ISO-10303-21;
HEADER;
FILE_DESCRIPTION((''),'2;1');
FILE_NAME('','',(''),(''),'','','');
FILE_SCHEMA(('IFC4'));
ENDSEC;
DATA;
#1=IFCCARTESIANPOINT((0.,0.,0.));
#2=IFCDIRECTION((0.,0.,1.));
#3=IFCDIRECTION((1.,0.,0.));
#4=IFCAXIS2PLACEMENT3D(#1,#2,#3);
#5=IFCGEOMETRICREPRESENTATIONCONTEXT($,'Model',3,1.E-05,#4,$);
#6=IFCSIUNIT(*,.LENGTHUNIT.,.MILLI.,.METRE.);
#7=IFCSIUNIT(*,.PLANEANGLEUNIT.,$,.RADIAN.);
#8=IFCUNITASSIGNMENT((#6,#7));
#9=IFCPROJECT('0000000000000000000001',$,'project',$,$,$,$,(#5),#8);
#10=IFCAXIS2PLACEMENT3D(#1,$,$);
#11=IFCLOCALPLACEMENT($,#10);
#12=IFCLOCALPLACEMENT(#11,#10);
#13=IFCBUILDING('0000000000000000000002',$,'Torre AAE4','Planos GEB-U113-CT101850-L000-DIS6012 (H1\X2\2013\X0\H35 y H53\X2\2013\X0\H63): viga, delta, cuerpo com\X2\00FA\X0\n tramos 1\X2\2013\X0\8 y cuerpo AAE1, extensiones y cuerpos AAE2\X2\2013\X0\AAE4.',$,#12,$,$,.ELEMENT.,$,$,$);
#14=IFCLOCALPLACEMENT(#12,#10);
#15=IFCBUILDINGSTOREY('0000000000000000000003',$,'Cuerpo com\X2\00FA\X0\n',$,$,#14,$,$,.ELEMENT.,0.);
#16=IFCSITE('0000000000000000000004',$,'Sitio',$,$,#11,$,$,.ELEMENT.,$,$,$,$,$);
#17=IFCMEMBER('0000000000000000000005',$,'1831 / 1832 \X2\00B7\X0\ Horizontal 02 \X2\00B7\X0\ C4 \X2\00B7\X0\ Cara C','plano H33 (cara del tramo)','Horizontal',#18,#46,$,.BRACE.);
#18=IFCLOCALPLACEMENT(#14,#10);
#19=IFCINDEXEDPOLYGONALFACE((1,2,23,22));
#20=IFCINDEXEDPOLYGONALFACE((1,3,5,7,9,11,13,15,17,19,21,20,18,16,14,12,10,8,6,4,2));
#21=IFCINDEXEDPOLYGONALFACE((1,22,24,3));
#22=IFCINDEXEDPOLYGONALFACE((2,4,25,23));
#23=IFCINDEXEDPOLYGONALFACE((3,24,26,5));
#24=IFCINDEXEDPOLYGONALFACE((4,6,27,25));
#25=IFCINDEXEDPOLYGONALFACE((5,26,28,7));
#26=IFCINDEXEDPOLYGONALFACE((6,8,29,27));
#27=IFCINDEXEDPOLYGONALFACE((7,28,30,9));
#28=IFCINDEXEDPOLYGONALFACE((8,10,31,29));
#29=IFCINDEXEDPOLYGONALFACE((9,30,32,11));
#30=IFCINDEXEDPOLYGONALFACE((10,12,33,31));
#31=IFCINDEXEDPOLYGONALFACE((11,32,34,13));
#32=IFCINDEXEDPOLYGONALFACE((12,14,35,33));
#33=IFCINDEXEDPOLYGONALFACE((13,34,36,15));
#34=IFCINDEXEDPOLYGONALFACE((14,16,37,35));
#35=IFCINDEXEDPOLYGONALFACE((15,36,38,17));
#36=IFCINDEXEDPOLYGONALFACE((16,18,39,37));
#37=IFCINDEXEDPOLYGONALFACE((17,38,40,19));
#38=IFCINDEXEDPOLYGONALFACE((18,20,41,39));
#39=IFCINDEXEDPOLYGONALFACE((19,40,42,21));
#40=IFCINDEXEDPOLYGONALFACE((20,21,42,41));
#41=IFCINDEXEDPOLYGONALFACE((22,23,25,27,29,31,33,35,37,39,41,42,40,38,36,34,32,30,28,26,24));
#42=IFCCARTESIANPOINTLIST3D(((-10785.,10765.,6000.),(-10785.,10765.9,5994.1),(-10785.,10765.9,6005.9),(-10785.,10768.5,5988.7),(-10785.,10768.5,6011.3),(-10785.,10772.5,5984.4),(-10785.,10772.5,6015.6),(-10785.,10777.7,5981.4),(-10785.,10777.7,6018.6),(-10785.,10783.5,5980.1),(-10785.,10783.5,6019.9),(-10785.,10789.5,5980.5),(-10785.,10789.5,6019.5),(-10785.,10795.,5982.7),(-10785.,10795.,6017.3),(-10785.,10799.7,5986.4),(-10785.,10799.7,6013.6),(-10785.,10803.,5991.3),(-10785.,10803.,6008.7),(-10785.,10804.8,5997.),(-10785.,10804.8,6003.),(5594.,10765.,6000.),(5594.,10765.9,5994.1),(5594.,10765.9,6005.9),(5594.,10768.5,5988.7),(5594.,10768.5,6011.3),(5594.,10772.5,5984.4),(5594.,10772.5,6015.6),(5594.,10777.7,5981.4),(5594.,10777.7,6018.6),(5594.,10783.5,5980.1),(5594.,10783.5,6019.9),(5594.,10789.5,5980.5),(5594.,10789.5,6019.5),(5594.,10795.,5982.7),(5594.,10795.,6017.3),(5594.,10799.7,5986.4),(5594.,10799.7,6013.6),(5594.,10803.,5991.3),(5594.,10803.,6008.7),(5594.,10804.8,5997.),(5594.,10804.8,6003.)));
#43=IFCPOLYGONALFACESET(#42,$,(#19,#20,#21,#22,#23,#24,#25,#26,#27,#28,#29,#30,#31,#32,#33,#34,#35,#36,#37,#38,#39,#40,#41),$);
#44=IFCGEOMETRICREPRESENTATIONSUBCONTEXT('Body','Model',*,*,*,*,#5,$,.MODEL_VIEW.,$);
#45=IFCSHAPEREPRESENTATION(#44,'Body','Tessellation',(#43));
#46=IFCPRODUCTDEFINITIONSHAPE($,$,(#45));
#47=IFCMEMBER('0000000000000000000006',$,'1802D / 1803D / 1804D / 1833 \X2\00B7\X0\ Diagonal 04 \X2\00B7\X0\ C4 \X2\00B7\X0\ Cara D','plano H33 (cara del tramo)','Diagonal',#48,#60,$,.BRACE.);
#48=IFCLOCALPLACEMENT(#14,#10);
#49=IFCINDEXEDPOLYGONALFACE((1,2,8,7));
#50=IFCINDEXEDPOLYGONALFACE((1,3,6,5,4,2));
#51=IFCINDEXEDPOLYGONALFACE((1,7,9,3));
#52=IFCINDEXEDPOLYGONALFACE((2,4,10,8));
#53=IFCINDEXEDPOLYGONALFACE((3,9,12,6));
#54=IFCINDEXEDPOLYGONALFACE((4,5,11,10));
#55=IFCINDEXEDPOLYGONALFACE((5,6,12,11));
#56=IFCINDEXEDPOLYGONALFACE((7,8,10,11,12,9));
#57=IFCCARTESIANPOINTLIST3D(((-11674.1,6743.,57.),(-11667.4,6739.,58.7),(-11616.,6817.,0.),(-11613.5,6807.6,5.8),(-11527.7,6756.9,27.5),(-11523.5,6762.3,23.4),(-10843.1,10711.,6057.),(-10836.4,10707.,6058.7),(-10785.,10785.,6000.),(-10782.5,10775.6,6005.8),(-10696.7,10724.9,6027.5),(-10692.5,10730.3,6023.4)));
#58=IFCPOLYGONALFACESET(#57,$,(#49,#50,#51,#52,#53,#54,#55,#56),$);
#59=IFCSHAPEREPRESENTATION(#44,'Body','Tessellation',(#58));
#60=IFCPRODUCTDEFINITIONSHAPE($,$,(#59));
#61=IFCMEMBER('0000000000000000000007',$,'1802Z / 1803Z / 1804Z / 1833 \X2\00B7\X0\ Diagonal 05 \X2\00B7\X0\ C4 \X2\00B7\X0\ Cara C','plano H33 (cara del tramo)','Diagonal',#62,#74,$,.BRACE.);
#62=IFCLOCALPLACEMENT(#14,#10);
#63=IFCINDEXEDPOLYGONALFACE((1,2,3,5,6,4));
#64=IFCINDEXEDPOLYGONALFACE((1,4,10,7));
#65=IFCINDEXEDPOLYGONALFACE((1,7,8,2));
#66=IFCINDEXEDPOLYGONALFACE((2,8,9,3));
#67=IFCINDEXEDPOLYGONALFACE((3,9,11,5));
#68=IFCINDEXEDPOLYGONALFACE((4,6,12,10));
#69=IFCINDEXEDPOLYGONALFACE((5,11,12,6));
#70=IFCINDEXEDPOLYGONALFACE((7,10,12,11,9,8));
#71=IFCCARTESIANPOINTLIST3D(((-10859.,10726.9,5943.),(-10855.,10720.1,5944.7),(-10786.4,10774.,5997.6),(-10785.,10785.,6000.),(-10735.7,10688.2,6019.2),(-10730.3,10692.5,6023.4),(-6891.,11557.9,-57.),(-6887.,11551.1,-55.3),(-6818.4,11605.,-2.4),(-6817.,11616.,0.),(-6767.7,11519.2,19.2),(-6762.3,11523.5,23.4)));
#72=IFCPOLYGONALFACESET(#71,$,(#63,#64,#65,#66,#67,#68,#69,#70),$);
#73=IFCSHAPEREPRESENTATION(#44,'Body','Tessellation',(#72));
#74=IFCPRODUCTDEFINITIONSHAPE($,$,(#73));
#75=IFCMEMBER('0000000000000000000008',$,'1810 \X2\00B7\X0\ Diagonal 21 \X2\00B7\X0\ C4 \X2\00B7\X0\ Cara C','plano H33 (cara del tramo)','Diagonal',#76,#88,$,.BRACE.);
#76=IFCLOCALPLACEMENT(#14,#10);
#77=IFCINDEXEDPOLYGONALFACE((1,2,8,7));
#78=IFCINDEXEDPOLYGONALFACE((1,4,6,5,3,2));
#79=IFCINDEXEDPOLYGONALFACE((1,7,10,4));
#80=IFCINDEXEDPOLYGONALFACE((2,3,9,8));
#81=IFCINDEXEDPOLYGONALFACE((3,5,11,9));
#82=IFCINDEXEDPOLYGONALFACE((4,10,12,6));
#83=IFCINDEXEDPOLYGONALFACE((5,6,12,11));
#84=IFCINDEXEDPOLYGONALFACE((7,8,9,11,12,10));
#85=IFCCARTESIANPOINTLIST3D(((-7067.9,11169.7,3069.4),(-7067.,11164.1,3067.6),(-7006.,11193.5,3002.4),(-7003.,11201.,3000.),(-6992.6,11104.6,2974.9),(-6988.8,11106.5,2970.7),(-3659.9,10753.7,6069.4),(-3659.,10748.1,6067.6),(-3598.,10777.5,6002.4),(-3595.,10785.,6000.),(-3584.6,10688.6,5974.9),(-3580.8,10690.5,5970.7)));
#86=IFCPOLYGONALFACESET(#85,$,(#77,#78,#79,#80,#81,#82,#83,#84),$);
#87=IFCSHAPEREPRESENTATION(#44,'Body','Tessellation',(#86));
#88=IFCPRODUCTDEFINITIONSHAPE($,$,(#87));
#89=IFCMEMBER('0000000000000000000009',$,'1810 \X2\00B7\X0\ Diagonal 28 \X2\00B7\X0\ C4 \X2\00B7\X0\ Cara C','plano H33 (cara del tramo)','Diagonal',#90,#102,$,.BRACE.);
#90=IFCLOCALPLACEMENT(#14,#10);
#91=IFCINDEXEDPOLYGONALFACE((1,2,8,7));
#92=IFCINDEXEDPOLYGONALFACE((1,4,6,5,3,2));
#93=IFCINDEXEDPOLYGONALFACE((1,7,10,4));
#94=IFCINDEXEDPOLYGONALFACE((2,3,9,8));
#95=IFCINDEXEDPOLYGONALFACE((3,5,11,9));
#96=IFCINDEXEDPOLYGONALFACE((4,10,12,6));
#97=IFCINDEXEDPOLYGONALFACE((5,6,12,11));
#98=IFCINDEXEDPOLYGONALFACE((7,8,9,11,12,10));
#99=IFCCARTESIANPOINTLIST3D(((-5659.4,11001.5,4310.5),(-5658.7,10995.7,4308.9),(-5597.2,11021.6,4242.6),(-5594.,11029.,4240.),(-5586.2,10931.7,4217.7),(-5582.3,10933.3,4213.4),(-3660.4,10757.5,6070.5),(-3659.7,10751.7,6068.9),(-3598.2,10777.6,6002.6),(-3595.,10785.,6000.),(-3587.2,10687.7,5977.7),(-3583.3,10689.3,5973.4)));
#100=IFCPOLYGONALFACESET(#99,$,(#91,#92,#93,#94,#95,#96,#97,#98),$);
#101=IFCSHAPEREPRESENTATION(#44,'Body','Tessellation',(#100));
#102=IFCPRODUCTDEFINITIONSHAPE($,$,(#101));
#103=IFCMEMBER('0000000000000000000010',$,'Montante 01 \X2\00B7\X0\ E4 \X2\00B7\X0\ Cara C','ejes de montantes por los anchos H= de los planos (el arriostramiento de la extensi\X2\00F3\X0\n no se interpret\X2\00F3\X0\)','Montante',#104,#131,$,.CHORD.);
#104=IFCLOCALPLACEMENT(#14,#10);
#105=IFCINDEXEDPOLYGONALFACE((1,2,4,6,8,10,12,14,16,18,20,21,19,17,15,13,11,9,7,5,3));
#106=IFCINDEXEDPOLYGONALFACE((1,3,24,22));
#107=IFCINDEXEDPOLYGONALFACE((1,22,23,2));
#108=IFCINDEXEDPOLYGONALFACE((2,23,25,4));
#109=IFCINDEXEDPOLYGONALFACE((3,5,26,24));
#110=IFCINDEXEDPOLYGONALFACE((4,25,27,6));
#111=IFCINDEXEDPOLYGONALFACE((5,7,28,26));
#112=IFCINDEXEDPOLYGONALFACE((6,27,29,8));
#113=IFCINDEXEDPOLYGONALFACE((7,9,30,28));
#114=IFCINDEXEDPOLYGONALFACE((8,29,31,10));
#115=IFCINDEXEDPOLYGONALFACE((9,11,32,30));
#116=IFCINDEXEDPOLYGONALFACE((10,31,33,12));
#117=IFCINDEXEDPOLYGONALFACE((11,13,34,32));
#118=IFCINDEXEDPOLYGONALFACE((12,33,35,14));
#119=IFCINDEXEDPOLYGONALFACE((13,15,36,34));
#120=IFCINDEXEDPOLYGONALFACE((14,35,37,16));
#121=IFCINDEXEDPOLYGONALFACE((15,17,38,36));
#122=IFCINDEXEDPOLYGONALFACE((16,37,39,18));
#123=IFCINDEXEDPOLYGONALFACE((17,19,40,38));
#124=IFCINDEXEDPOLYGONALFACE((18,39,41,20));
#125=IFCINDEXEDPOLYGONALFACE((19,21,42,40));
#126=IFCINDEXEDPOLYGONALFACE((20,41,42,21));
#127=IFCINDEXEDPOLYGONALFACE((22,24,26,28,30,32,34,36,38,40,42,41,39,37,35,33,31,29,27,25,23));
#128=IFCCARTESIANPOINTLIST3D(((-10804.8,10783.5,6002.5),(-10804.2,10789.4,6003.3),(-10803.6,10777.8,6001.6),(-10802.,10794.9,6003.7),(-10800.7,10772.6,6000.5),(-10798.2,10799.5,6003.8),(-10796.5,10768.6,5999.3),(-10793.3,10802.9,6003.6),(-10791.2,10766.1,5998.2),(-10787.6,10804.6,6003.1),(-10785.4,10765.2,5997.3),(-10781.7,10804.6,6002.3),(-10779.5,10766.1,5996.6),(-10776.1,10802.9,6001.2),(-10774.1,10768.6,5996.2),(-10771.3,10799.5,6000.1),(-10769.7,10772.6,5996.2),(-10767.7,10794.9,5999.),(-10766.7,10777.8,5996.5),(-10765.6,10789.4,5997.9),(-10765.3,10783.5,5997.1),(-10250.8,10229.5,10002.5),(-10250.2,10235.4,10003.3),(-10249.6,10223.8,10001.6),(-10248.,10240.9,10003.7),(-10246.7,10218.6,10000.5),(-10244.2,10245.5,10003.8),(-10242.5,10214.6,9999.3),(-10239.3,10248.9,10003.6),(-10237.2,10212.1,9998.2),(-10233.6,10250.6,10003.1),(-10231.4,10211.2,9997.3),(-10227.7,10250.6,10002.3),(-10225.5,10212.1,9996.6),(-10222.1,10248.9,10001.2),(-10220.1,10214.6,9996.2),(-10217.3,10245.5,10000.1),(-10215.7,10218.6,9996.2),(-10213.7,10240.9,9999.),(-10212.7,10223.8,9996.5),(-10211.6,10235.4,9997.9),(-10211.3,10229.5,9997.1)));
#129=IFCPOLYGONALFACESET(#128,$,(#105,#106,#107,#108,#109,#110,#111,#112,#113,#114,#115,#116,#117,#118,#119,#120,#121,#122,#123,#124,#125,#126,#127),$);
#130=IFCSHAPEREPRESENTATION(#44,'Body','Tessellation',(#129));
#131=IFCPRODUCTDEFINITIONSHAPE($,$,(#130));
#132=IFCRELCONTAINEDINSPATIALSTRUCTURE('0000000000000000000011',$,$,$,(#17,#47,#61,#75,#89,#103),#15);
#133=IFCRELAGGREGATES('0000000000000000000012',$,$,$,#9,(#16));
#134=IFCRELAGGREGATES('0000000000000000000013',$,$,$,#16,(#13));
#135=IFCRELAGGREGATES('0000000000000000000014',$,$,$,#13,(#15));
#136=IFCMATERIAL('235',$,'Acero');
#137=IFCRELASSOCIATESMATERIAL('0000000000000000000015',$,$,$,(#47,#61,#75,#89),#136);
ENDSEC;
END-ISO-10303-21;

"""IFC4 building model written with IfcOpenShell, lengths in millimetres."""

from ifc_helpers import new_model, si_unit, frame, frame_2d, origin, origin_with_axes, place, context, subcontext, project, spatial, circle, l_section, extrude, material, element, save


model = new_model("IFC4")

# Units and contexts
model_context = context("Model", 3, precision=1e-05, world=origin_with_axes())
body_context = subcontext(model_context, "Body", "Model", "MODEL_VIEW")
ifc_project = project(units=[si_unit("LENGTHUNIT", "METRE", prefix="MILLI"), si_unit("PLANEANGLEUNIT", "RADIAN")], contexts=[model_context])

# Site, building, storey
site_placement = place(None, origin())
site = spatial("IfcSite", under=ifc_project, at=site_placement, Name="Sitio", CompositionType="ELEMENT")
building_placement = place(site_placement, origin())
building = spatial("IfcBuilding", under=site, at=building_placement, Name="Torre AAE4", Description="Planos GEB-U113-CT101850-L000-DIS6012 (H1–H35 y H53–H63): viga, delta, cuerpo común tramos 1–8 y cuerpo AAE1, extensiones y cuerpos AAE2–AAE4.", CompositionType="ELEMENT")
storey_placement = place(building_placement, origin())
storey = spatial("IfcBuildingStorey", under=building, at=storey_placement, Name="Cuerpo común", CompositionType="ELEMENT", Elevation=0.0)

# Members
ifc_material_1 = material(Name="235", Category="Acero")
member_1_placement = place(storey_placement, frame((-10785.0, 10785.0, 6000.0), z_axis=(1.0, 0.0, 0.0), x_axis=(0.0, -1.0, 0.0)))
element("IfcMember", 1, at=member_1_placement, inside=storey, Name="1831 / 1832 · Horizontal 02 · C4 · Cara C", Description="plano H33 (cara del tramo)", ObjectType="Horizontal", PredefinedType="BRACE", context=body_context, shape_type="SweptSolid", body=[
    extrude(circle(Radius=20.0), None, (0.0, 0.0, 1.0), 16379.0),
])
for number, where, z_axis, x_axis, name in (
    (2, (-10785.0, 10785.0, 6000.0), (-0.114759, -0.547972, -0.828587), (0.841144, -0.49735, 0.212416), "1802D / 1803D / 1804D / 1833 · Diagonal 04 · C4 · Cara D"),
    (3, (-10785.0, 10785.0, 6000.0), (0.547972, 0.114759, -0.828587), (0.49735, -0.841144, 0.212416), "1802Z / 1803Z / 1804Z / 1833 · Diagonal 05 · C4 · Cara C"),
):
    element("IfcMember", number, at=place(storey_placement, frame(where, z_axis=z_axis, x_axis=x_axis)), inside=storey, material=ifc_material_1, Name=name, Description="plano H33 (cara del tramo)", ObjectType="Diagonal", PredefinedType="BRACE", context=body_context, shape_type="SweptSolid", body=[
        extrude(l_section(Depth=110.0, Width=110.0, Thickness=8.0, at=frame_2d((55.0, 55.0))), None, (0.0, 0.0, 1.0), 7241.2),
    ])
member_2_placement = place(storey_placement, frame((-3595.0, 10785.0, 6000.0), z_axis=(-0.747478, 0.091241, -0.657991), x_axis=(0.142496, -0.945441, -0.292977)))
element("IfcMember", 4, at=member_2_placement, inside=storey, material=ifc_material_1, Name="1810 · Diagonal 21 · C4 · Cara C", Description="plano H33 (cara del tramo)", ObjectType="Diagonal", PredefinedType="BRACE", context=body_context, shape_type="SweptSolid", body=[
    extrude(l_section(Depth=100.0, Width=100.0, Thickness=6.0, at=frame_2d((50.0, 50.0))), None, (0.0, 0.0, 1.0), 4559.3),
])
member_3_placement = place(storey_placement, frame((-3595.0, 10785.0, 6000.0), z_axis=(-0.74742, 0.091231, -0.658058), x_axis=(0.117002, -0.956968, -0.265561)))
element("IfcMember", 5, at=member_3_placement, inside=storey, material=ifc_material_1, Name="1810 · Diagonal 28 · C4 · Cara C", Description="plano H33 (cara del tramo)", ObjectType="Diagonal", PredefinedType="BRACE", context=body_context, shape_type="SweptSolid", body=[
    extrude(l_section(Depth=100.0, Width=100.0, Thickness=6.0, at=frame_2d((50.0, 50.0))), None, (0.0, 0.0, 1.0), 2674.5),
])
member_4_placement = place(storey_placement, frame((-10785.0, 10785.0, 6000.0), z_axis=(0.135917, -0.135917, 0.981353), x_axis=(-0.018647, -0.99072, -0.134632)))
element("IfcMember", 6, at=member_4_placement, inside=storey, Name="Montante 01 · E4 · Cara C", Description="ejes de montantes por los anchos H= de los planos (el arriostramiento de la extensión no se interpretó)", ObjectType="Montante", PredefinedType="CHORD", context=body_context, shape_type="SweptSolid", body=[
    extrude(circle(Radius=20.0), None, (0.0, 0.0, 1.0), 4076.0),
])

save(model, "model.ifc")
